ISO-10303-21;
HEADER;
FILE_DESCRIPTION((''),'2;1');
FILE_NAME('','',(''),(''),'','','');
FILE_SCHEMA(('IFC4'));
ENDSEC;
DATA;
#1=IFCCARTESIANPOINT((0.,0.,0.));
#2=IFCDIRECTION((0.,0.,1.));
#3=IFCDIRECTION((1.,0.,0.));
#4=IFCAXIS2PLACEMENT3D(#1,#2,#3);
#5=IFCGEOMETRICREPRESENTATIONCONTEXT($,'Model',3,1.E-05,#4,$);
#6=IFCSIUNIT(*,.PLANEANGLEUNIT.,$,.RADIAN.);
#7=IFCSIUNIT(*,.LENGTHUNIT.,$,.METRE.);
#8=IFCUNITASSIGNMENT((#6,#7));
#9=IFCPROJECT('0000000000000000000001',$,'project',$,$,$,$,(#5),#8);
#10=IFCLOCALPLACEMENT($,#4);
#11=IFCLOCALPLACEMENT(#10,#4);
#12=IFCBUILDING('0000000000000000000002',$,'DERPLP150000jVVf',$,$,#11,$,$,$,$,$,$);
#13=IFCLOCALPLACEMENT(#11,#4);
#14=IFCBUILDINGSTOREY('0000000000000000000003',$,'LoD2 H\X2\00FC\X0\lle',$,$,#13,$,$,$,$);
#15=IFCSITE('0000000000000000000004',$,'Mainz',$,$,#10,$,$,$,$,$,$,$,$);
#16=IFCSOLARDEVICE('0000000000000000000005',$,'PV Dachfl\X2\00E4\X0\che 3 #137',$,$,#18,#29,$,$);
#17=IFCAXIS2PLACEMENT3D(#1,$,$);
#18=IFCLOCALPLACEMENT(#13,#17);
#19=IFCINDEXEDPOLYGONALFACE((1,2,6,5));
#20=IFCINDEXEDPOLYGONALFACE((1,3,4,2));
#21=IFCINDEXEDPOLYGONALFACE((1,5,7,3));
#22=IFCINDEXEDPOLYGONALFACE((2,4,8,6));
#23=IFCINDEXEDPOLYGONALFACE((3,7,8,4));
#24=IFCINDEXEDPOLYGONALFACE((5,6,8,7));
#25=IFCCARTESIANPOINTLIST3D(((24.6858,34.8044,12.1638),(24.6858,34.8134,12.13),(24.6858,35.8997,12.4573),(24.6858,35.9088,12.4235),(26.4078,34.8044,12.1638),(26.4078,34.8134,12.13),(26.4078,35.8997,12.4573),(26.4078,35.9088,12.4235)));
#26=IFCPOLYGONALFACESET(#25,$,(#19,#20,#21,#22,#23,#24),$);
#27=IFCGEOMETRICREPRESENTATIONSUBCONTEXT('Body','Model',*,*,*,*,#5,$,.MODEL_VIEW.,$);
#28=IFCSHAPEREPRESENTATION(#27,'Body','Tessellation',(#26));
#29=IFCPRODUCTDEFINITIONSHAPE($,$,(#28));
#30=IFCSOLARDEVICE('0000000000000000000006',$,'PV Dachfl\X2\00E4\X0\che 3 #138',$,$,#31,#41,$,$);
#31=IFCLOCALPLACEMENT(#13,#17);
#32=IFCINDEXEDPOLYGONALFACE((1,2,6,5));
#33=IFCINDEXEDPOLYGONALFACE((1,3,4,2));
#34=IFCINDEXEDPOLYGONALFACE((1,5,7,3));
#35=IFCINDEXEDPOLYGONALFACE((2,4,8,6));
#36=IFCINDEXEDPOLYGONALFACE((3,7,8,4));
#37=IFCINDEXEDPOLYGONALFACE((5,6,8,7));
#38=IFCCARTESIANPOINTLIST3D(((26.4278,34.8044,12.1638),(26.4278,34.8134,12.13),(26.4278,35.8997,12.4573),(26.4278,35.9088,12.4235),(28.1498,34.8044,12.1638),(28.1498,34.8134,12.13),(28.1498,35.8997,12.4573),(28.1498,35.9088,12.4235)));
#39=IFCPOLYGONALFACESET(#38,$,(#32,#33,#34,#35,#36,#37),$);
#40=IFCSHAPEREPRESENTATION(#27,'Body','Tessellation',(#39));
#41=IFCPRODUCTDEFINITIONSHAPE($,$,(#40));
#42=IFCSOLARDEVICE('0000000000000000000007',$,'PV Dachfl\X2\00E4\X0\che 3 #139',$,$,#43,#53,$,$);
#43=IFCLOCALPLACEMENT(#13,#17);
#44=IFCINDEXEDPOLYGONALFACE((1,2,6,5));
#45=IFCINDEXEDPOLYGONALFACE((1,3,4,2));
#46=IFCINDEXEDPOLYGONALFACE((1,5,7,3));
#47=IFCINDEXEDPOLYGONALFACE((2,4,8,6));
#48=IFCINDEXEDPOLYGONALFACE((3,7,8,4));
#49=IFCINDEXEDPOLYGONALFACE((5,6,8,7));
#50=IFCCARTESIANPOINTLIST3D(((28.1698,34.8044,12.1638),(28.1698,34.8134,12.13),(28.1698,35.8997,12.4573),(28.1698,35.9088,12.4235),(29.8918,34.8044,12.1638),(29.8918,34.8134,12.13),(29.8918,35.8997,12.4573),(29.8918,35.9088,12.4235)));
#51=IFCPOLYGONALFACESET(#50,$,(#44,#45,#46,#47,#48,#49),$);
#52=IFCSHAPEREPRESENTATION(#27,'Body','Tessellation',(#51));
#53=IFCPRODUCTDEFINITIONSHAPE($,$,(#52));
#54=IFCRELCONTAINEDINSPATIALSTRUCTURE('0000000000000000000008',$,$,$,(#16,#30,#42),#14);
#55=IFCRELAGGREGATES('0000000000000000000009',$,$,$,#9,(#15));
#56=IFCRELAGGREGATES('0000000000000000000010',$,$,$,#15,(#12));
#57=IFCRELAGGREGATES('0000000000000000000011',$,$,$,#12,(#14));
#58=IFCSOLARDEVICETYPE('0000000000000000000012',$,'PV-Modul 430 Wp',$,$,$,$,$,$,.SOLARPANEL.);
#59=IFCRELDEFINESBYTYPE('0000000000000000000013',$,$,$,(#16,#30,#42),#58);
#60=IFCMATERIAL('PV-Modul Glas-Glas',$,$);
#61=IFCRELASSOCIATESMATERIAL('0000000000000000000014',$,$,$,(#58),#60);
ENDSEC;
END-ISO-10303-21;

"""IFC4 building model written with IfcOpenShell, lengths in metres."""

from ifc_helpers import new_model, si_unit, frame, frame_2d, origin, origin_with_axes, place, context, subcontext, project, spatial, rectangle, extrude, source, transform, mapped, material, type_object, type_shapes, element, save


model = new_model("IFC4")

# Units and contexts
model_context = context("Model", 3, precision=1e-05, world=origin_with_axes())
body_context = subcontext(model_context, "Body", "Model", "MODEL_VIEW")
ifc_project = project(units=[si_unit("PLANEANGLEUNIT", "RADIAN"), si_unit("LENGTHUNIT", "METRE")], contexts=[model_context])

# Site, building, storey
site_placement = place(None, origin_with_axes())
site = spatial("IfcSite", under=ifc_project, at=site_placement, Name="Mainz")
building_placement = place(site_placement, origin_with_axes())
building = spatial("IfcBuilding", under=site, at=building_placement, Name="DERPLP150000jVVf")
storey_placement = place(building_placement, origin_with_axes())
storey = spatial("IfcBuildingStorey", under=building, at=storey_placement, Name="LoD2 Hülle")

# Solar devices
ifc_material = material(Name="PV-Modul Glas-Glas")
solar_device_type = type_object("IfcSolarDeviceType", Name="PV-Modul 430 Wp", PredefinedType="SOLARPANEL", material=ifc_material)
shared_shape = source(origin_with_axes(), body_context, "Body", "SweptSolid", [
    extrude(rectangle(XDim=1.722, YDim=1.134, at=frame_2d((0.861, 0.567))), origin(), (0.0, 0.0, 1.0), 0.035),
])
type_shapes(solar_device_type, [shared_shape])
for number, where, z_axis, x_axis, name in (
    (1, (24.6858, 34.8134, 12.13), (0.0, -0.258819, 0.965926), (1.0, 0.0, 0.0), "PV Dachfläche 3 #137"),
    (2, (26.4278, 34.8134, 12.13), (0.0, -0.258819, 0.965926), (1.0, 0.0, 0.0), "PV Dachfläche 3 #138"),
    (3, (28.1698, 34.8134, 12.13), (0.0, -0.258819, 0.965926), (1.0, 0.0, 0.0), "PV Dachfläche 3 #139"),
):
    element("IfcSolarDevice", number, at=place(storey_placement, frame(where, z_axis=z_axis, x_axis=x_axis)), inside=storey, type_object=solar_device_type, Name=name, context=body_context, shape_type="MappedRepresentation", body=[
        mapped(shared_shape, transform((0.0, 0.0, 0.0), x_axis=(1.0, 0.0, 0.0), y_axis=(0.0, 1.0, 0.0), z_axis=(0.0, 0.0, 1.0), scale=1.0)),
    ])

save(model, "model.ifc")
